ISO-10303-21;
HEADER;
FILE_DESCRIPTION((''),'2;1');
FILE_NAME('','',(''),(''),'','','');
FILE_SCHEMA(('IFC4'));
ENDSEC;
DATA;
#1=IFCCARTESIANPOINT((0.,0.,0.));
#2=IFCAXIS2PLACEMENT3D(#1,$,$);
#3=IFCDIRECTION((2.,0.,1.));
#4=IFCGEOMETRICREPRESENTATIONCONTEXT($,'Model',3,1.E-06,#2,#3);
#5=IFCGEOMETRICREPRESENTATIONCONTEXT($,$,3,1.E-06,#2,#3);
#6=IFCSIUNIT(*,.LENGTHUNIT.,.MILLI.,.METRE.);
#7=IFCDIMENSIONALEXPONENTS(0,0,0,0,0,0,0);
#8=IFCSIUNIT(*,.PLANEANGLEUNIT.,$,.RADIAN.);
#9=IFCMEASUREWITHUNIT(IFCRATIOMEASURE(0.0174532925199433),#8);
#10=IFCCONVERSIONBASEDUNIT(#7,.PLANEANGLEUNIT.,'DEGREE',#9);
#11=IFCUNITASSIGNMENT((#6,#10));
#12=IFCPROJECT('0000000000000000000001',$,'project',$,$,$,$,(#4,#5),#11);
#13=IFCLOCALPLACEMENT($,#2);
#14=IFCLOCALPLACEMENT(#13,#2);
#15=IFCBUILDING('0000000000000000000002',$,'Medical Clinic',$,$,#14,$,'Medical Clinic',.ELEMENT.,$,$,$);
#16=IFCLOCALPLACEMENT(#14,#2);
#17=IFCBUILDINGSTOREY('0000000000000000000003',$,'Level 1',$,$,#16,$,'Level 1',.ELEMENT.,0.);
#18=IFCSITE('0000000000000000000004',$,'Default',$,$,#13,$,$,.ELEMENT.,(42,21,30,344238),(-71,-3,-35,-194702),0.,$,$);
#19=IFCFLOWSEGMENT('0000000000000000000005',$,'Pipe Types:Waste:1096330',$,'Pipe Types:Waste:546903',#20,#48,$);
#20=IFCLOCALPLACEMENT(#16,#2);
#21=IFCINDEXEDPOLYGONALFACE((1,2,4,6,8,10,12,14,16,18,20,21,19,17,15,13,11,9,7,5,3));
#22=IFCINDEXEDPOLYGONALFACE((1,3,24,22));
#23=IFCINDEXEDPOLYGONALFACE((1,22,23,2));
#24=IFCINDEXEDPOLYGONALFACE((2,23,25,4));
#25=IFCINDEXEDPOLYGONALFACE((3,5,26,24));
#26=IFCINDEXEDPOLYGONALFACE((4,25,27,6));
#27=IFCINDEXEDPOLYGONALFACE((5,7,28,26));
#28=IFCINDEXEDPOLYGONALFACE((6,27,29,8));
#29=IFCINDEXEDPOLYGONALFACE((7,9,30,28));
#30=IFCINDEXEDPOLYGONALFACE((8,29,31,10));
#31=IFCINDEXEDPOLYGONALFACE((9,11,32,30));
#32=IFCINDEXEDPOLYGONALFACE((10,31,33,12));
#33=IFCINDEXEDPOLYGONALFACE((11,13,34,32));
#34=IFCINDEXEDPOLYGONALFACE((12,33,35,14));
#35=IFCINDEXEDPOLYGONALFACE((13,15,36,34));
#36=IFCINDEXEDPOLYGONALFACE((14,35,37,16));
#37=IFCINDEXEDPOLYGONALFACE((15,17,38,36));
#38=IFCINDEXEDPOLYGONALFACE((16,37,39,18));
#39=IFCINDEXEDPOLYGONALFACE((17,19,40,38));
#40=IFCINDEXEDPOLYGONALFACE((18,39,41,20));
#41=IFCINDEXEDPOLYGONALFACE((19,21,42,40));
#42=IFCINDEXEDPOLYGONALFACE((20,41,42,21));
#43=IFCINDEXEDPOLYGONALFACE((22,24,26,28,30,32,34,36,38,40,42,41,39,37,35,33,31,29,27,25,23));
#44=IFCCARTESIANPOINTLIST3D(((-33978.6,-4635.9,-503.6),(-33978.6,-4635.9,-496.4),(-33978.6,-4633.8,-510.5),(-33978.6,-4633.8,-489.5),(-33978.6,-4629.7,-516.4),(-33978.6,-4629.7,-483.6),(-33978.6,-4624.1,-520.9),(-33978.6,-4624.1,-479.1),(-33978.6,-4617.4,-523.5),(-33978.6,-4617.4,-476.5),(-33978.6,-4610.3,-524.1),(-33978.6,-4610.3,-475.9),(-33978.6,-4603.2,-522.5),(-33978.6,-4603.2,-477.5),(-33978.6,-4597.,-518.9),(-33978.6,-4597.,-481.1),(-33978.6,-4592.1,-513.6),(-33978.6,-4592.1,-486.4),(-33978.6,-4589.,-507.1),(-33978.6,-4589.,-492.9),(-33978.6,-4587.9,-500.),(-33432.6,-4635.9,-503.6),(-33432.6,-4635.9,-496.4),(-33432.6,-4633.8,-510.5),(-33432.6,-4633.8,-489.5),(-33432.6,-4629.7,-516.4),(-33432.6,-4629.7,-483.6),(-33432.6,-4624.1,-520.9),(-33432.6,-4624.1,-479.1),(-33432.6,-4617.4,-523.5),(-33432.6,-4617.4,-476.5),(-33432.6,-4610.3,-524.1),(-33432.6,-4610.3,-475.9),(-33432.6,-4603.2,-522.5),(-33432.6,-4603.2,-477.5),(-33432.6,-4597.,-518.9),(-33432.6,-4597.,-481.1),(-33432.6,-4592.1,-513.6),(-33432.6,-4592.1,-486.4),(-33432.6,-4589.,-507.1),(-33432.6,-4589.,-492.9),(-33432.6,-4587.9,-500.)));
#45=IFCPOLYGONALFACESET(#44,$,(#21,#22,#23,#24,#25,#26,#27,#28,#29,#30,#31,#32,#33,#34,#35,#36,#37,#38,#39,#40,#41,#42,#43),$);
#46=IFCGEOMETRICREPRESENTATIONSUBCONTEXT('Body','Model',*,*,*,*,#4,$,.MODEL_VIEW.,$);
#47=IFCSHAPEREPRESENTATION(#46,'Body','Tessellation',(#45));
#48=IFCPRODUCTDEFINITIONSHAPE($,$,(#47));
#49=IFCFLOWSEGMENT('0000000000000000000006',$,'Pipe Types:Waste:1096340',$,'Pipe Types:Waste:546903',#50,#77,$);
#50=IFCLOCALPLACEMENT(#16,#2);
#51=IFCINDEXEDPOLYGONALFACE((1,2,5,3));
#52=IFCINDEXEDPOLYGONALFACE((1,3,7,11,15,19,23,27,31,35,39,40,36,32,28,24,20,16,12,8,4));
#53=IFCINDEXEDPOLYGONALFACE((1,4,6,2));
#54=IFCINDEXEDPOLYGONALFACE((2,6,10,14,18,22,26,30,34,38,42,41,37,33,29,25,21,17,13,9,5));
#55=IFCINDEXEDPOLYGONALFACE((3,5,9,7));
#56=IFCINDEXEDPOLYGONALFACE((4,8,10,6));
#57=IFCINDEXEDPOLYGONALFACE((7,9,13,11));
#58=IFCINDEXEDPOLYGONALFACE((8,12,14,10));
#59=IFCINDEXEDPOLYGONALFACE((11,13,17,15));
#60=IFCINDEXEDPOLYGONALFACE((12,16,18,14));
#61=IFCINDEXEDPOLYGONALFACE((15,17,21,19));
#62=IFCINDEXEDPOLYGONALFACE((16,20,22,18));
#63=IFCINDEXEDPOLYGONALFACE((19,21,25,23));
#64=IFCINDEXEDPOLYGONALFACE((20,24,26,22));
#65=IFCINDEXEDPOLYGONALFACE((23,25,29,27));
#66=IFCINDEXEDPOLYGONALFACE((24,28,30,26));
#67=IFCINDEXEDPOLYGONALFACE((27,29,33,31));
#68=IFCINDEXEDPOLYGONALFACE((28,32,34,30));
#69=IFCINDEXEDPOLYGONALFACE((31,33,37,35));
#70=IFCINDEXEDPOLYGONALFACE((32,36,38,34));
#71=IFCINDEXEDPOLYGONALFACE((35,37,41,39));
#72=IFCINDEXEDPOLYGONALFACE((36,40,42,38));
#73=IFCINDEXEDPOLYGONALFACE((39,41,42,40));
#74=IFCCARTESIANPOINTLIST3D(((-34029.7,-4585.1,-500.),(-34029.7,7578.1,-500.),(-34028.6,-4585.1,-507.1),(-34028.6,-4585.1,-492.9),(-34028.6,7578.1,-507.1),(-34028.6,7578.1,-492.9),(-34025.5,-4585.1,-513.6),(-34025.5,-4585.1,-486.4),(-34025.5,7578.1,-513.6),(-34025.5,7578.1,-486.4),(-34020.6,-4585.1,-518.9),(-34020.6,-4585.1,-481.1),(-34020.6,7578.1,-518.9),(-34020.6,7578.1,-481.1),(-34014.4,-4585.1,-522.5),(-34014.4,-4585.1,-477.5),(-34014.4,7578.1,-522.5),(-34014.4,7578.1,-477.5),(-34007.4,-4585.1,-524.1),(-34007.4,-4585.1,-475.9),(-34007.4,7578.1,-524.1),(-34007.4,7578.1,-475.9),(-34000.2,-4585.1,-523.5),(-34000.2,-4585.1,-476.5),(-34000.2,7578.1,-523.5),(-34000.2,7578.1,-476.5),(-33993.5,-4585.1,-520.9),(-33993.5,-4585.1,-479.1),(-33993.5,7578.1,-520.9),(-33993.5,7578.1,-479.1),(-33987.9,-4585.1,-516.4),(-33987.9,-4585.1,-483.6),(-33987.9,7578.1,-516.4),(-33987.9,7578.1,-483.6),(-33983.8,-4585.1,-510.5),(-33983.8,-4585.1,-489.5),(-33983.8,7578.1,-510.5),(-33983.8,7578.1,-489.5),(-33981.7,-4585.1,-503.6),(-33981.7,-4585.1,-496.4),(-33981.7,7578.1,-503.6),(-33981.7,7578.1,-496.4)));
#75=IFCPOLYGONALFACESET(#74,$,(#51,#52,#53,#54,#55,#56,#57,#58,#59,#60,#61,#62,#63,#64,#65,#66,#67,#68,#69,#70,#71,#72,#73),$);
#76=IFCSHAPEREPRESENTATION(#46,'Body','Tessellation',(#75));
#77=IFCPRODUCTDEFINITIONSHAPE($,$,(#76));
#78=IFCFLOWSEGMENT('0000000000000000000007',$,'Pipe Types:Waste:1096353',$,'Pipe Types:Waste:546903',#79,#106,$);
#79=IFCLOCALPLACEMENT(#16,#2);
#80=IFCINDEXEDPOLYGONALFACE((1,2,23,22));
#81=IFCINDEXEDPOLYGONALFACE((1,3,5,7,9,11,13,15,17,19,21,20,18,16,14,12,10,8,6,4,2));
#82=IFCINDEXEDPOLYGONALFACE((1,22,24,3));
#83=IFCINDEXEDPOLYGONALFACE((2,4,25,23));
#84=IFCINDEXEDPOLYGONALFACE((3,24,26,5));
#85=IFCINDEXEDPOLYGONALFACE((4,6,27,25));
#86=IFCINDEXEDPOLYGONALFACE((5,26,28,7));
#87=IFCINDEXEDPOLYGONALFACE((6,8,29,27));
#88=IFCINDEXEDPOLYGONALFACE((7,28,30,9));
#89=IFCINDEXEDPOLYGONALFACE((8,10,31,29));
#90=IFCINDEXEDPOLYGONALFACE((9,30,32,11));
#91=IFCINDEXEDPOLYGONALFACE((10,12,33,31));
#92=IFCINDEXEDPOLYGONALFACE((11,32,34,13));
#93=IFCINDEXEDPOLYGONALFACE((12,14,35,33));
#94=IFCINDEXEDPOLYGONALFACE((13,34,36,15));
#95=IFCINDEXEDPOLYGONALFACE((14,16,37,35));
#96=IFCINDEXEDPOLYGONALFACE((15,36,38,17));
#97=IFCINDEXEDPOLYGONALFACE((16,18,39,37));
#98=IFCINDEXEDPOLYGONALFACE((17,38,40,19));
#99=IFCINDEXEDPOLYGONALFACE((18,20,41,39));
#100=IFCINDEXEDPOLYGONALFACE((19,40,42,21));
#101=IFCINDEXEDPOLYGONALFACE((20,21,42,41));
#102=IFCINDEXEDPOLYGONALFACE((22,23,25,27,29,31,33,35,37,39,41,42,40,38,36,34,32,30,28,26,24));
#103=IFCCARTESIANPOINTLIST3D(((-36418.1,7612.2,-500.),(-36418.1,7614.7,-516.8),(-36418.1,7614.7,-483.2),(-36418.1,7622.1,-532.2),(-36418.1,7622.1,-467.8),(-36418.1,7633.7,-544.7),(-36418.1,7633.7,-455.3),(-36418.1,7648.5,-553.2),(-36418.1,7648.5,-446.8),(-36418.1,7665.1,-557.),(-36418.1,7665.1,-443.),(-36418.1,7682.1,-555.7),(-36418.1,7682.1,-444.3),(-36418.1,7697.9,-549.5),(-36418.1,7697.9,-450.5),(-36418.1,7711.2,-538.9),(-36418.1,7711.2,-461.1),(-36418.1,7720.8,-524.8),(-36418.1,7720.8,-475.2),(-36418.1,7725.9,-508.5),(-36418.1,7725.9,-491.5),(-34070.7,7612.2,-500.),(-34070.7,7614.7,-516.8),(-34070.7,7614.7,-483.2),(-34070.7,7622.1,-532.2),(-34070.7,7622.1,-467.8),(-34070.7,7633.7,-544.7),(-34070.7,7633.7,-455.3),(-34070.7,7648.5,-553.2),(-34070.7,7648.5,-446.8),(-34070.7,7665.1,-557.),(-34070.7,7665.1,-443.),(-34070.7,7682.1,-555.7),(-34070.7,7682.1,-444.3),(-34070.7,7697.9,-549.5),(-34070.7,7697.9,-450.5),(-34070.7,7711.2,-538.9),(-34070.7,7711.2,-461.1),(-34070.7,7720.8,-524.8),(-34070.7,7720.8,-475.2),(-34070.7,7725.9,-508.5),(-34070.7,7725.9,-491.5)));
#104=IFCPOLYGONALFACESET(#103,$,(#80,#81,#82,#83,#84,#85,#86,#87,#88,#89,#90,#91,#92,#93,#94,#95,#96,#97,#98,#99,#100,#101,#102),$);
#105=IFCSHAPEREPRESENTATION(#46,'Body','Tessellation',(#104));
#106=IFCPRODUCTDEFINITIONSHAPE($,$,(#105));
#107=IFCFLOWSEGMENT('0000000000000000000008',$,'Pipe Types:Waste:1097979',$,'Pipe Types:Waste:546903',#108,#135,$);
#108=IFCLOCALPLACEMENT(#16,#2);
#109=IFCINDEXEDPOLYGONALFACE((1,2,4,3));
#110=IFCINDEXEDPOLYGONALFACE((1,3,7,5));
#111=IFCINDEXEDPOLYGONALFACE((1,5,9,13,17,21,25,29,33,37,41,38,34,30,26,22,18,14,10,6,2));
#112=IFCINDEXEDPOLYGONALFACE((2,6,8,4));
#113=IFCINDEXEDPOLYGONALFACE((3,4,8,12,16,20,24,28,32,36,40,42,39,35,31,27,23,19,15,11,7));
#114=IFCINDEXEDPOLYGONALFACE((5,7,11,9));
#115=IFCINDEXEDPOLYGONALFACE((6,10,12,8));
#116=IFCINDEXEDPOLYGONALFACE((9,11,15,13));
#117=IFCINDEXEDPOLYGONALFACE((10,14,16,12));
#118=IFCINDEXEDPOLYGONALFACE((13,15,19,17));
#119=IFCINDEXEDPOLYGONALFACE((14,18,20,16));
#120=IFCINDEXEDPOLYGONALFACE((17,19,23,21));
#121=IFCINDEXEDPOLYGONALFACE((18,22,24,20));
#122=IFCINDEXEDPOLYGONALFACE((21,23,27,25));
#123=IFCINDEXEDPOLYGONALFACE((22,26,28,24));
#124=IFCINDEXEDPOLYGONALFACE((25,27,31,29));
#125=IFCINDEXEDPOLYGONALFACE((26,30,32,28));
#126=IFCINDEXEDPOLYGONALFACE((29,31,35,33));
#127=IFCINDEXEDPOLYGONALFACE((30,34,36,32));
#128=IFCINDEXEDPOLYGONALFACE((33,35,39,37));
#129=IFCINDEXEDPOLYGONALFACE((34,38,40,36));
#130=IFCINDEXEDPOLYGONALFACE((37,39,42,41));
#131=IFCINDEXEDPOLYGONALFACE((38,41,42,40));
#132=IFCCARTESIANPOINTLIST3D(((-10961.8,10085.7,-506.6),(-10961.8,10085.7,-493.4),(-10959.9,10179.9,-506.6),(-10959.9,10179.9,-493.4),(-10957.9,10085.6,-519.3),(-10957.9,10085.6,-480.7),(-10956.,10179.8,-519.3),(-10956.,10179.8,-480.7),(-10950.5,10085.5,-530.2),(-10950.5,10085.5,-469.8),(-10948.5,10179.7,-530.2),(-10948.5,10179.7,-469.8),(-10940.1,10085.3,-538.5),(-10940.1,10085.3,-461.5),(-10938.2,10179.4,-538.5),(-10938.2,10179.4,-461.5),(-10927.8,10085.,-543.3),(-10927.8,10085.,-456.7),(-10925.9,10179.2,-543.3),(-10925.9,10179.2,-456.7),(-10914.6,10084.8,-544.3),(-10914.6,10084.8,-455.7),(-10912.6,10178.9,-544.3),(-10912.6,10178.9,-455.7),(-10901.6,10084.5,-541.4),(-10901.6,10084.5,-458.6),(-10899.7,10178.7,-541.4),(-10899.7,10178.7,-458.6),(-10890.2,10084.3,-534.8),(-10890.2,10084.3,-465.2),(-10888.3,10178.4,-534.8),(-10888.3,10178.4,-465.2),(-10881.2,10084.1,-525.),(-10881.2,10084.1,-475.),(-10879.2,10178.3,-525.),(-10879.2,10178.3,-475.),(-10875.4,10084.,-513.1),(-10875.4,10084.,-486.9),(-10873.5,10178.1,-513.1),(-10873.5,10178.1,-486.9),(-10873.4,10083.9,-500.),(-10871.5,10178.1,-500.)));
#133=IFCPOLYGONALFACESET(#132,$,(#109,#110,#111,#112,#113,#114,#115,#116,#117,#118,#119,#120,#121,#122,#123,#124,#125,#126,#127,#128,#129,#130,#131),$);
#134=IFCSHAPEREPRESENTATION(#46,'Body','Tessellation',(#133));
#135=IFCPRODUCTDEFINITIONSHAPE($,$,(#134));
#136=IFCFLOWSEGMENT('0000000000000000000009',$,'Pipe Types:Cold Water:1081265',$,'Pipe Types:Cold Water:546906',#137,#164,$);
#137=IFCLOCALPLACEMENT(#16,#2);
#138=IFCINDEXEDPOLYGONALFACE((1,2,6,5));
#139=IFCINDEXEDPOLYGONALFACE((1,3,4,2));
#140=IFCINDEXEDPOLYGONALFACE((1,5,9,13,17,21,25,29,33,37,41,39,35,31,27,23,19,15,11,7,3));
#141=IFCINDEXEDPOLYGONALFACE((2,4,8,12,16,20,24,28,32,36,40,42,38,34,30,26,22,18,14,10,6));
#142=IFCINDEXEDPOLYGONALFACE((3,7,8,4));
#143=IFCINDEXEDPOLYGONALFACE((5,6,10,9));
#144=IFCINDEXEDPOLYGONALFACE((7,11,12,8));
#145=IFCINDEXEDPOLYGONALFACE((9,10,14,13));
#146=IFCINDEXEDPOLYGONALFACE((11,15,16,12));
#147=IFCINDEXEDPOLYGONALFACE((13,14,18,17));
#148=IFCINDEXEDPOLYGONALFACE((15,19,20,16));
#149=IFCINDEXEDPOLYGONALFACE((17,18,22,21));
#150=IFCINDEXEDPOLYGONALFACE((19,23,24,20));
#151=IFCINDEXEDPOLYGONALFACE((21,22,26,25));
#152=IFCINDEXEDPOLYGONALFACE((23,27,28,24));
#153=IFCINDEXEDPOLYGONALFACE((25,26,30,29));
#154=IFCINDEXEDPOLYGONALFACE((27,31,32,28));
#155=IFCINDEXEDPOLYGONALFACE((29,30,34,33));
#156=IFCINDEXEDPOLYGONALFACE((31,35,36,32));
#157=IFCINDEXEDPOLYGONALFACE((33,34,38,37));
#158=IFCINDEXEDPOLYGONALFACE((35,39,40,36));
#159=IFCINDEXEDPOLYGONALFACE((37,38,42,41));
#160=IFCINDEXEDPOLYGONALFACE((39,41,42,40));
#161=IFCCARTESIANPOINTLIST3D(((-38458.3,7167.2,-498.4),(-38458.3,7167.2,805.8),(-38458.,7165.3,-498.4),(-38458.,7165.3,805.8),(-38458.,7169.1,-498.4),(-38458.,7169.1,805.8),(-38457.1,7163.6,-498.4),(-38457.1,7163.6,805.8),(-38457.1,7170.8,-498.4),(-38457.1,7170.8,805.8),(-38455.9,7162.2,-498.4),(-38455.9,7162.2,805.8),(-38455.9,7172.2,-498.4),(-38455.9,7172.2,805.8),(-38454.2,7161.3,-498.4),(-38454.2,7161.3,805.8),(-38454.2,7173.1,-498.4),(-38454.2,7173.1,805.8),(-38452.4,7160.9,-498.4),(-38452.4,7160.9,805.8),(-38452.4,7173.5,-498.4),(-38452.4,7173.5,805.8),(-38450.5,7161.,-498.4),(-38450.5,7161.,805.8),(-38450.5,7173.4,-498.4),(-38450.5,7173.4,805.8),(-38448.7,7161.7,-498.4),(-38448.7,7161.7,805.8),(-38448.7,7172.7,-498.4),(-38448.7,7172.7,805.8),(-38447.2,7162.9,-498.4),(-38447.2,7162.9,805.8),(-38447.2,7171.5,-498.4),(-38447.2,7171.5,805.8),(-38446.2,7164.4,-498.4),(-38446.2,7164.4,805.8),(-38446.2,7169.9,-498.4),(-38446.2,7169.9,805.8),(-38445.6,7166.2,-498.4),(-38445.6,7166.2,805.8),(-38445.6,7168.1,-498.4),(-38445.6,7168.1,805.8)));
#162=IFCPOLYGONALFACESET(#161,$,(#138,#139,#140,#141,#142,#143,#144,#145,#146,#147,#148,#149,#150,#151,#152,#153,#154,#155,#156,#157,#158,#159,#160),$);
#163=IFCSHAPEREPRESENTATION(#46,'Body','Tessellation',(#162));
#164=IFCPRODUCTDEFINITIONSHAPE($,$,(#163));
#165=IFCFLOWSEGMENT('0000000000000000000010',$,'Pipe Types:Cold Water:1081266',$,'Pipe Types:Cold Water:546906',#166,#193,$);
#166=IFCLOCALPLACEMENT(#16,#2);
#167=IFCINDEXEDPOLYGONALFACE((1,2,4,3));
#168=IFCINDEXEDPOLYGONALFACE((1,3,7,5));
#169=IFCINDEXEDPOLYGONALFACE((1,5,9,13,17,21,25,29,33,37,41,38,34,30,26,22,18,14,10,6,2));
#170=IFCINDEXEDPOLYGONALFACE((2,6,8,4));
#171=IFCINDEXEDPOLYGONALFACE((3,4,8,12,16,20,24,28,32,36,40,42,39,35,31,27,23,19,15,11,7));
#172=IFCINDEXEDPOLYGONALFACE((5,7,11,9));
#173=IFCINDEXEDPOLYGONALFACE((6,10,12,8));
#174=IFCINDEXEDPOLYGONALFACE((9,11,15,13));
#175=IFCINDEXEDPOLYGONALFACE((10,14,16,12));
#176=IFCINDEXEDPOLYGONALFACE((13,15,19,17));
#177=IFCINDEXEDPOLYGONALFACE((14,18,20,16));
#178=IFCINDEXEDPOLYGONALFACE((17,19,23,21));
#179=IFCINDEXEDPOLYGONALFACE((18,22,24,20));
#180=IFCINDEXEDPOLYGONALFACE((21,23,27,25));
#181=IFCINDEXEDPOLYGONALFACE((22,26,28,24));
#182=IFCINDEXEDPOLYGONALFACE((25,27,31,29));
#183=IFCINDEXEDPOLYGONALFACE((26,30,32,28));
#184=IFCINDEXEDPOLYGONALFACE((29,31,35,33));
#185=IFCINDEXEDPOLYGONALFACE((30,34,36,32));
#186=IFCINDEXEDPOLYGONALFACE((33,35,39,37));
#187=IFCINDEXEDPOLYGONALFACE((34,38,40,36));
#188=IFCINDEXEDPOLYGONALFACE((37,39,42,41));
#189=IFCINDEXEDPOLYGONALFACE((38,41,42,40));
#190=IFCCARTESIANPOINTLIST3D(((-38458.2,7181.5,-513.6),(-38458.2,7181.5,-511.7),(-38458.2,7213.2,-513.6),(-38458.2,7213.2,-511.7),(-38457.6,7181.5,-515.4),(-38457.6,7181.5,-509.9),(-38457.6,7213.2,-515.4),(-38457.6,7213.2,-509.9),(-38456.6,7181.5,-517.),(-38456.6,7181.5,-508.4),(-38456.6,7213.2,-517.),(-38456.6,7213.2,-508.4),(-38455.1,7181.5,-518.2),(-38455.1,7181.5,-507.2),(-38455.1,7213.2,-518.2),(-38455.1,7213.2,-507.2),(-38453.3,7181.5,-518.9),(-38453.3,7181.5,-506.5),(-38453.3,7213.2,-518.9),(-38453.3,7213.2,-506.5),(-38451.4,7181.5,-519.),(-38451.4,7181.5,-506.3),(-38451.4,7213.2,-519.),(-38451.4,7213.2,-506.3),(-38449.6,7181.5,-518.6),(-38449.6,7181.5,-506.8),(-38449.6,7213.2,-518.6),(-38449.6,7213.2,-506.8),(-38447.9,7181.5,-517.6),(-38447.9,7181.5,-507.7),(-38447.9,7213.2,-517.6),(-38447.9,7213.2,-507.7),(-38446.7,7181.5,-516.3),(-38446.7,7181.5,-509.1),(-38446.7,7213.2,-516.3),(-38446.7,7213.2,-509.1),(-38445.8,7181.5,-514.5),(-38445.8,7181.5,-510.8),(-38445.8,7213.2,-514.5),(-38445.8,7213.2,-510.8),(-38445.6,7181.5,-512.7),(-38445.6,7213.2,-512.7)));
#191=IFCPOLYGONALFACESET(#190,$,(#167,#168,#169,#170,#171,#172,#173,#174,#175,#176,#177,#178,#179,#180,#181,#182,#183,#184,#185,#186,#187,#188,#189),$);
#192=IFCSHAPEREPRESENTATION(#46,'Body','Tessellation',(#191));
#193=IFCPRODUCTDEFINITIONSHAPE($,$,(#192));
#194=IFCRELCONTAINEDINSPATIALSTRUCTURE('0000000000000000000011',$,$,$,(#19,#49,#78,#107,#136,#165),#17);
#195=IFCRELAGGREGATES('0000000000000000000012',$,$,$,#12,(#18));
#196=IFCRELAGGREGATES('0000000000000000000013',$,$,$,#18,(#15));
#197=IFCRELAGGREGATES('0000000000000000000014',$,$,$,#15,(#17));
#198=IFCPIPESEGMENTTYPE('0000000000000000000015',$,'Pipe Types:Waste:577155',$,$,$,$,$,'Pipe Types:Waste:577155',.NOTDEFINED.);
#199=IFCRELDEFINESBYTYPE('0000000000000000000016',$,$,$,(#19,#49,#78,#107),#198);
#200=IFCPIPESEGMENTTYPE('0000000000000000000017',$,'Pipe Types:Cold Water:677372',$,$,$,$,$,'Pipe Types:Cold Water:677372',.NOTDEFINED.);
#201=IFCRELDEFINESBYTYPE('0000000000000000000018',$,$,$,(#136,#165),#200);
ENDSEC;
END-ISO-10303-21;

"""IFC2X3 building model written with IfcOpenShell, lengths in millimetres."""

from ifc_helpers import new_model, entity, si_unit, converted_unit, direction, frame, frame_2d, origin, origin_2d_with_axis, place, context, subcontext, project, spatial, circle, extrude, type_object, element, save


model = new_model("IFC2X3")

# Units and contexts
model_context = context("Model", 3, precision=1e-06, world=origin(), true_north=direction((2.0, 0.0, 1.0)))
context_of_model = context(None, 3, precision=1e-06, world=origin(), true_north=direction((2.0, 0.0, 1.0)))
body_context = subcontext(model_context, "Body", "Model", "MODEL_VIEW")
ifc_project = project(units=[si_unit("LENGTHUNIT", "METRE", prefix="MILLI"), converted_unit("PLANEANGLEUNIT", "DEGREE", entity("IfcRatioMeasure", 0.0174532925199433), si_unit("PLANEANGLEUNIT", "RADIAN"), dimensions=[0, 0, 0, 0, 0, 0, 0])], contexts=[model_context, context_of_model])

# Site, building, storey
site_placement = place(None, origin())
site = spatial("IfcSite", under=ifc_project, at=site_placement, Name="Default", CompositionType="ELEMENT", RefLatitude=(42, 21, 30, 344238), RefLongitude=(-71, -3, -35, -194702), RefElevation=0.0)
building_placement = place(site_placement, origin())
building = spatial("IfcBuilding", under=site, at=building_placement, Name="Medical Clinic", LongName="Medical Clinic", CompositionType="ELEMENT")
storey_placement = place(building_placement, origin())
storey = spatial("IfcBuildingStorey", under=building, at=storey_placement, Name="Level 1", LongName="Level 1", CompositionType="ELEMENT", Elevation=0.0)

# Flow segments
pipe_segment_type_1 = type_object("IfcPipeSegmentType", Name="Pipe Types:Waste:577155", ElementType="Pipe Types:Waste:577155", PredefinedType="NOTDEFINED")
flow_segment_1_placement = place(storey_placement, origin())
element("IfcFlowSegment", 1, at=flow_segment_1_placement, inside=storey, type_object=pipe_segment_type_1, Name="Pipe Types:Waste:1096330", ObjectType="Pipe Types:Waste:546903", context=body_context, shape_type="SweptSolid", body=[
    extrude(circle(Radius=24.1, at=frame_2d((0.0, 0.0), x_axis=(1.0, 0.0))), frame((-33978.6, -4612.1, -500.0), z_axis=(1.0, 0.0, 0.0), x_axis=(0.0, 1.0, 0.0)), (0.0, 0.0, 1.0), 546.0),
])
flow_segment_2_placement = place(storey_placement, origin())
element("IfcFlowSegment", 2, at=flow_segment_2_placement, inside=storey, type_object=pipe_segment_type_1, Name="Pipe Types:Waste:1096340", ObjectType="Pipe Types:Waste:546903", context=body_context, shape_type="SweptSolid", body=[
    extrude(circle(Radius=24.1, at=origin_2d_with_axis()), frame((-34005.6, -4585.1, -500.0), z_axis=(0.0, 1.0, 0.0), x_axis=(-1.0, 0.0, 0.0)), (0.0, 0.0, 1.0), 12163.1),
])
flow_segment_3_placement = place(storey_placement, origin())
element("IfcFlowSegment", 3, at=flow_segment_3_placement, inside=storey, type_object=pipe_segment_type_1, Name="Pipe Types:Waste:1096353", ObjectType="Pipe Types:Waste:546903", context=body_context, shape_type="SweptSolid", body=[
    extrude(circle(Radius=57.1, at=frame_2d((0.0, 0.0), x_axis=(1.0, 0.0))), frame((-36418.1, 7669.4, -500.0), z_axis=(1.0, 0.0, 0.0), x_axis=(0.0, -1.0, 0.0)), (0.0, 0.0, 1.0), 2347.4),
])
flow_segment_4_placement = place(storey_placement, origin())
element("IfcFlowSegment", 4, at=flow_segment_4_placement, inside=storey, type_object=pipe_segment_type_1, Name="Pipe Types:Waste:1097979", ObjectType="Pipe Types:Waste:546903", context=body_context, shape_type="SweptSolid", body=[
    extrude(circle(Radius=44.5, at=frame_2d((0.0, 0.0), x_axis=(1.0, 0.0))), frame((-10917.9, 10084.8, -500.0), z_axis=(0.020287, 0.999794, 0.0), x_axis=(0.999794, -0.020287, 0.0)), (0.0, 0.0, 1.0), 94.2),
])
pipe_segment_type_2 = type_object("IfcPipeSegmentType", Name="Pipe Types:Cold Water:677372", ElementType="Pipe Types:Cold Water:677372", PredefinedType="NOTDEFINED")
flow_segment_5_placement = place(storey_placement, origin())
element("IfcFlowSegment", 5, at=flow_segment_5_placement, inside=storey, type_object=pipe_segment_type_2, Name="Pipe Types:Cold Water:1081265", ObjectType="Pipe Types:Cold Water:546906", context=body_context, shape_type="SweptSolid", body=[
    extrude(circle(Radius=6.3, at=frame_2d((0.0, 0.0), x_axis=(1.0, 0.0))), frame((-38451.9, 7167.2, -498.4), z_axis=(0.0, 0.0, 1.0), x_axis=(-1.0, 0.0, 0.0)), (0.0, 0.0, 1.0), 1304.2),
])
flow_segment_6_placement = place(storey_placement, origin())
element("IfcFlowSegment", 6, at=flow_segment_6_placement, inside=storey, type_object=pipe_segment_type_2, Name="Pipe Types:Cold Water:1081266", ObjectType="Pipe Types:Cold Water:546906", context=body_context, shape_type="SweptSolid", body=[
    extrude(circle(Radius=6.3, at=origin_2d_with_axis()), frame((-38451.9, 7181.5, -512.7), z_axis=(0.0, 1.0, 0.0), x_axis=(1.0, 0.0, 0.0)), (0.0, 0.0, 1.0), 31.7),
])

save(model, "model.ifc")
